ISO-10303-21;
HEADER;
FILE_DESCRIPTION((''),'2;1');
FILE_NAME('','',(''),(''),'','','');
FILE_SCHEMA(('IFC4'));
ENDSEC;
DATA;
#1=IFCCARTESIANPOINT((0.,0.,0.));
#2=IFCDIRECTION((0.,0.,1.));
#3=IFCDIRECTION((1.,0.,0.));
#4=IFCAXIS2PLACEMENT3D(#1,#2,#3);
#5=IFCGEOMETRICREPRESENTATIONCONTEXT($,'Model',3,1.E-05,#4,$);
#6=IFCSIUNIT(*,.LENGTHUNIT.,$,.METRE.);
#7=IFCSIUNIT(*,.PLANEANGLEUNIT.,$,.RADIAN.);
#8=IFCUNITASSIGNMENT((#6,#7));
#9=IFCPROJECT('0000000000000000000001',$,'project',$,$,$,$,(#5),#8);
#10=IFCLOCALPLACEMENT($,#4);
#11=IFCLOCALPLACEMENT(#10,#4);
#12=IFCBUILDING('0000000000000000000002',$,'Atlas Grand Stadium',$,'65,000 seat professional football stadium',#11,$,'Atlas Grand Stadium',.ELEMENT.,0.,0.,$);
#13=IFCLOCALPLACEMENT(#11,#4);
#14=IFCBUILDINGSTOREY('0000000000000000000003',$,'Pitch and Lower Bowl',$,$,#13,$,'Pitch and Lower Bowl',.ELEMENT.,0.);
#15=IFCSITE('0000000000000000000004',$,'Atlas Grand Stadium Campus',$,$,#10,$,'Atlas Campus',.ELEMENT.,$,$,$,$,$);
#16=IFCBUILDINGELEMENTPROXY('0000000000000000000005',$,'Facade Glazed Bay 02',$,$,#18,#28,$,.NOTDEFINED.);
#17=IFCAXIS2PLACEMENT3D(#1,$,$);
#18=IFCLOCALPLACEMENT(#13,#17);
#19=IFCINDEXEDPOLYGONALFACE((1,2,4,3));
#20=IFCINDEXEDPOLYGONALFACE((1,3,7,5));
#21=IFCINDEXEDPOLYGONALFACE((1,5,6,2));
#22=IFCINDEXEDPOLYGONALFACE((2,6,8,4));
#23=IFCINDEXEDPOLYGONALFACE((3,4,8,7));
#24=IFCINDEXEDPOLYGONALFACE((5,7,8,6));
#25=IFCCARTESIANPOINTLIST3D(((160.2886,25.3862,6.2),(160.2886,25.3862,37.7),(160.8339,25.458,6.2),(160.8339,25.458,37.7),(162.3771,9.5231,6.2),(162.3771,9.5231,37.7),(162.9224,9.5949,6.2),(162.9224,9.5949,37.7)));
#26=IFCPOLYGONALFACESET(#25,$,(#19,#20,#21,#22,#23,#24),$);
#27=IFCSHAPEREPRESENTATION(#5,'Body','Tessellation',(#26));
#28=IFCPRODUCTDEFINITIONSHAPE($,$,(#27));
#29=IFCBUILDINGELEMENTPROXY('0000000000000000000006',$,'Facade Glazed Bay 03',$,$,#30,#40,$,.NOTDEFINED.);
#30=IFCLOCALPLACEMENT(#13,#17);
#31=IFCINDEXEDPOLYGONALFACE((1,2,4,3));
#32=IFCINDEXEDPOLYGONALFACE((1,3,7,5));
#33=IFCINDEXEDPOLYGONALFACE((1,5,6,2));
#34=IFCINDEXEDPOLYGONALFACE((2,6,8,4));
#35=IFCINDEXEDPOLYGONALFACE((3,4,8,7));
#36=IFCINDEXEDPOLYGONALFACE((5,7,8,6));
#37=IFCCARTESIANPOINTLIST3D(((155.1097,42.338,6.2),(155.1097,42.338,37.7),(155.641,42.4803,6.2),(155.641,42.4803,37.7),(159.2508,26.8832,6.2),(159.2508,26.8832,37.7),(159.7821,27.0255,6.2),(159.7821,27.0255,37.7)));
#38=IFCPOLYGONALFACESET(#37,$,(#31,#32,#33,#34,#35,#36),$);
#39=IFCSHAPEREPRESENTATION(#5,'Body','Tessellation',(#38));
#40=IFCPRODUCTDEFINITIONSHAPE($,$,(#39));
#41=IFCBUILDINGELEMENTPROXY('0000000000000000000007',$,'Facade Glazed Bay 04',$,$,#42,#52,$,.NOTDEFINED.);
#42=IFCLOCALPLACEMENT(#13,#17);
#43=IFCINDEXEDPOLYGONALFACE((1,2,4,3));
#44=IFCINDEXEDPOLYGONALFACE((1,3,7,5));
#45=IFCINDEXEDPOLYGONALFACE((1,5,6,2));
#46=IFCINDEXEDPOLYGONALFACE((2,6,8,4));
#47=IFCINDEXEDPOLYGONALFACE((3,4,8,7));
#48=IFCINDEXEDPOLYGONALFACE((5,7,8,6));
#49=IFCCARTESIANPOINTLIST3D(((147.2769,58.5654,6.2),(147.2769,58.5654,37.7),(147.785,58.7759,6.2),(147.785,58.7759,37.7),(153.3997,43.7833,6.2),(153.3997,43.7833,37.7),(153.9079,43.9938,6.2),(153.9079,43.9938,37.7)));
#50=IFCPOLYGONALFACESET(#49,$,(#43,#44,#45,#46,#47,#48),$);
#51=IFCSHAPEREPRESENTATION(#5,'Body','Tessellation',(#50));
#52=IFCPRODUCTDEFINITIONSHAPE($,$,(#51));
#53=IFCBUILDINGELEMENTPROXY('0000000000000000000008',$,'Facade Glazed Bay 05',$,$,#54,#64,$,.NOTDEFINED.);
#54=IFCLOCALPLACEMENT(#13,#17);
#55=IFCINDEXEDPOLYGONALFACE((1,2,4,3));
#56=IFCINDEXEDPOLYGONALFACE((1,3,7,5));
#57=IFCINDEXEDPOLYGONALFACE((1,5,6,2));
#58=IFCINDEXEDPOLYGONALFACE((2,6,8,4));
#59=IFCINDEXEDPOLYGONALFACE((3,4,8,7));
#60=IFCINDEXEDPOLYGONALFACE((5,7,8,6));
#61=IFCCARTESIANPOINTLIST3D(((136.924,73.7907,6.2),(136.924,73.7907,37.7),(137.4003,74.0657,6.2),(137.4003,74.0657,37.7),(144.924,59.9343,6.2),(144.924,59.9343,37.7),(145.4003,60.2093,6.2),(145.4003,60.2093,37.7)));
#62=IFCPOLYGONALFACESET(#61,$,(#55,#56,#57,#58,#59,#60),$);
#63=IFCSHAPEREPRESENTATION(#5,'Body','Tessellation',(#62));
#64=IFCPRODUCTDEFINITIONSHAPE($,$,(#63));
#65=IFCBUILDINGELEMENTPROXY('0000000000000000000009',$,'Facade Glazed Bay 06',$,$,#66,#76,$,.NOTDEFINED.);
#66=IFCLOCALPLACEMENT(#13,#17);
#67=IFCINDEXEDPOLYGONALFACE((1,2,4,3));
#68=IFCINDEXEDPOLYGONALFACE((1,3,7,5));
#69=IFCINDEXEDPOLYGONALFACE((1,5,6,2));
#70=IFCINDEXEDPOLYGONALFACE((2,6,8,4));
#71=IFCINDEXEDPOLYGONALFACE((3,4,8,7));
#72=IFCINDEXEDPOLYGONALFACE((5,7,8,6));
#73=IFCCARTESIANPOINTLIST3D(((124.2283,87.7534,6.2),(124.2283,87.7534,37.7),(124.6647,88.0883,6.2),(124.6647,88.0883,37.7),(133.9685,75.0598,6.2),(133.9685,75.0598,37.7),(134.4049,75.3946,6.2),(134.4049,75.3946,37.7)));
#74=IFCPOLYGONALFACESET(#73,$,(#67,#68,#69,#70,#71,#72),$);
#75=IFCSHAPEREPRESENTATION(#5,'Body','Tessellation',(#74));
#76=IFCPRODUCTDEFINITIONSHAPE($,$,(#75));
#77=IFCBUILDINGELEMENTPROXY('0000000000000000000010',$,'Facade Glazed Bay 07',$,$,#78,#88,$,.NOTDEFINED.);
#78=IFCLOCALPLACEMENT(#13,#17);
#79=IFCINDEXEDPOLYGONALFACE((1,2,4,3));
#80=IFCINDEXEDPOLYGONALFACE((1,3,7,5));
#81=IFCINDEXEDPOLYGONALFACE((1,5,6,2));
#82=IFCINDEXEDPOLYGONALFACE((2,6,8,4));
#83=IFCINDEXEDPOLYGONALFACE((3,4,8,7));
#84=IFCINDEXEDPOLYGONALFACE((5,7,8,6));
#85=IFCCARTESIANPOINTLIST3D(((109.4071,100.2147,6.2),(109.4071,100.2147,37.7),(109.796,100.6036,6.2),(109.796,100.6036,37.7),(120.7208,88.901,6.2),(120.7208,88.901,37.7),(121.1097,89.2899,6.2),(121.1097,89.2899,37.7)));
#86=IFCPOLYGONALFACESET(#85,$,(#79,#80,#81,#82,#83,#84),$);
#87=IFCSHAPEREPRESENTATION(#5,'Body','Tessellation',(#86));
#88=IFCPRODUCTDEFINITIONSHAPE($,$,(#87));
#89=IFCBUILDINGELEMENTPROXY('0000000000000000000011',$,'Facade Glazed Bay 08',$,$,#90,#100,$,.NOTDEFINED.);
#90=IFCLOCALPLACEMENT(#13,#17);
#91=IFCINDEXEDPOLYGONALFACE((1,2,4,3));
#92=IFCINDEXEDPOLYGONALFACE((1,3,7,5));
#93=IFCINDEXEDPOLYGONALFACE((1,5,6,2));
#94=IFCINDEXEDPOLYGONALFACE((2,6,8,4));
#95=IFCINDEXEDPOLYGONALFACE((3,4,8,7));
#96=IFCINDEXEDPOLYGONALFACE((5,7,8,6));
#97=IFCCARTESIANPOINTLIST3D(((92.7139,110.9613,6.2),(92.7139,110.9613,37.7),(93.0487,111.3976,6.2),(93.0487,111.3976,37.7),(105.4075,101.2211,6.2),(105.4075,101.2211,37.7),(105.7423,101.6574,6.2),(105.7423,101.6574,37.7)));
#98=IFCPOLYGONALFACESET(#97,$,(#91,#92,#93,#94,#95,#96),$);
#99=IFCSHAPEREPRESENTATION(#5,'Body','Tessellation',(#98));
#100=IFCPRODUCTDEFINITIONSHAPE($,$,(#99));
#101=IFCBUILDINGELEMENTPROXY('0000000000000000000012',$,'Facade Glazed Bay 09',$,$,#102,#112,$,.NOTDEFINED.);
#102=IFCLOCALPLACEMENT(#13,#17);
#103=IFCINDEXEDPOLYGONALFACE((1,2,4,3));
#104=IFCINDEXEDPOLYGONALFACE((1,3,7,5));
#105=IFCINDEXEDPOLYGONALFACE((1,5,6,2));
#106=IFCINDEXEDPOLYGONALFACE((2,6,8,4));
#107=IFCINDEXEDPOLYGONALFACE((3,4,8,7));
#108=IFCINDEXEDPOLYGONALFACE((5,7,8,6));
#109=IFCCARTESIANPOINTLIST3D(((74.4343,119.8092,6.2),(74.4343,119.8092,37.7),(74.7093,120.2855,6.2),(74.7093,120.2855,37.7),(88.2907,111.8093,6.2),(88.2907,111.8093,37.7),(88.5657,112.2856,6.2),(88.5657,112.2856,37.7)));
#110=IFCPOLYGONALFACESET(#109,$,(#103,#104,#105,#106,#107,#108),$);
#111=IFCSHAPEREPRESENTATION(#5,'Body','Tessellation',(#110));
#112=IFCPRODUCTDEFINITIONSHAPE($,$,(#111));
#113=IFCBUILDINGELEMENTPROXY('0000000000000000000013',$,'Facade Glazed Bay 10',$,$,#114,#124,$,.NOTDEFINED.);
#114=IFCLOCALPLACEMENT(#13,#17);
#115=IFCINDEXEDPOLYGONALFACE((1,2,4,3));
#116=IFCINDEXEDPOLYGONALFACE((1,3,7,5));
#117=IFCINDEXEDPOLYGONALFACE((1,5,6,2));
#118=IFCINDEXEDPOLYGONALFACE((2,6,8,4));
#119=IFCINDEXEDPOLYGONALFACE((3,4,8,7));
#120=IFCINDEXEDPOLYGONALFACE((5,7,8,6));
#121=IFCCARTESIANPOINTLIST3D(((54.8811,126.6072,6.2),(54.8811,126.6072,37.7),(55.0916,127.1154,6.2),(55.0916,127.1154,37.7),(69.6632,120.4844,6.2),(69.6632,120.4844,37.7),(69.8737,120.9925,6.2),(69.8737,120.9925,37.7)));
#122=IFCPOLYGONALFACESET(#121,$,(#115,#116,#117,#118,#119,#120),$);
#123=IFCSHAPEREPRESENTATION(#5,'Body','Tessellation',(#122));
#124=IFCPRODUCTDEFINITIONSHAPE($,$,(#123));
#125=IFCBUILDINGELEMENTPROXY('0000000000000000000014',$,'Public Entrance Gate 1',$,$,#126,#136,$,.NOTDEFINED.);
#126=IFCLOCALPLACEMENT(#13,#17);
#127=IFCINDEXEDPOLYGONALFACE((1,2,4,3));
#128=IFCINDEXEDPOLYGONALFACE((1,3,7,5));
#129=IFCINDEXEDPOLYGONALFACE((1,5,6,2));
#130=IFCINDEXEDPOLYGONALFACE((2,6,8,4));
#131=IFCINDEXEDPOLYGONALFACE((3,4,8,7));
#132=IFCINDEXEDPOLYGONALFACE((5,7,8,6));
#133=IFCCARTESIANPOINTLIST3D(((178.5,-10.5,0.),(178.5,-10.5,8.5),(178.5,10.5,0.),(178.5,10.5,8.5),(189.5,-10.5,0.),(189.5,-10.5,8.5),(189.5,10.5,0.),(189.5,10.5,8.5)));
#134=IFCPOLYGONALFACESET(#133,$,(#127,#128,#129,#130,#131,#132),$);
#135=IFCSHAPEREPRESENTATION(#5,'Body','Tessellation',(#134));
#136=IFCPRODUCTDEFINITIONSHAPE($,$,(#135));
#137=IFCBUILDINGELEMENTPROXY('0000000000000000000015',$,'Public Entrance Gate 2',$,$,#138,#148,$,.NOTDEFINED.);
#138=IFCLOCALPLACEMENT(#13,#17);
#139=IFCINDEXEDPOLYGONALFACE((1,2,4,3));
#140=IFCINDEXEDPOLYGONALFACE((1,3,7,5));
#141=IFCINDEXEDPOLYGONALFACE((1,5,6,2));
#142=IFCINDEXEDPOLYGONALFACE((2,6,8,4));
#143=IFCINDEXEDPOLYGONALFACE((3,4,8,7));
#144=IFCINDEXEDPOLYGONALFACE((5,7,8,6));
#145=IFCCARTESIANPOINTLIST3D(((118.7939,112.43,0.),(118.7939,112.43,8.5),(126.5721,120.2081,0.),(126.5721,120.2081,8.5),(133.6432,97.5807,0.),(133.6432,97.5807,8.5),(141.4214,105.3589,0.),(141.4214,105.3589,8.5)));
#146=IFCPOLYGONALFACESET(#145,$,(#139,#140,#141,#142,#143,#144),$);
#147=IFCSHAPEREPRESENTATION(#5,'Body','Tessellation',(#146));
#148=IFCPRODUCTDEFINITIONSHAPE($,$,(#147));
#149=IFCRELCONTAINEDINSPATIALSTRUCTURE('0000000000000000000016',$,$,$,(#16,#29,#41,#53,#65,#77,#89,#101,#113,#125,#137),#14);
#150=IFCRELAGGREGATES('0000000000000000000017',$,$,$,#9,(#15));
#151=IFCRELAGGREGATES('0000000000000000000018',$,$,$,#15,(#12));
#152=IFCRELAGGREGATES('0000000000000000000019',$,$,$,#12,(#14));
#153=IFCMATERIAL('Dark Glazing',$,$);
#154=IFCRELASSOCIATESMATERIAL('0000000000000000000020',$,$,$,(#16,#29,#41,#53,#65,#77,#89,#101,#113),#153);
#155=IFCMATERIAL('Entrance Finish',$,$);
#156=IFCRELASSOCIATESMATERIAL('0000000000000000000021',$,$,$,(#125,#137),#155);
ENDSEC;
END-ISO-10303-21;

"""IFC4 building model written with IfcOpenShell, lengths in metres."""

from ifc_helpers import new_model, si_unit, frame, origin_with_axes, origin_2d_with_axis, place, context, project, spatial, rectangle, extrude, material, element, save


model = new_model("IFC4")

# Units and contexts
model_context = context("Model", 3, precision=1e-05, world=origin_with_axes())
ifc_project = project(units=[si_unit("LENGTHUNIT", "METRE"), si_unit("PLANEANGLEUNIT", "RADIAN")], contexts=[model_context])

# Site, building, storey
site_placement = place(None, origin_with_axes())
site = spatial("IfcSite", under=ifc_project, at=site_placement, Name="Atlas Grand Stadium Campus", LongName="Atlas Campus", CompositionType="ELEMENT")
building_placement = place(site_placement, origin_with_axes())
building = spatial("IfcBuilding", under=site, at=building_placement, Name="Atlas Grand Stadium", ObjectType="65,000 seat professional football stadium", LongName="Atlas Grand Stadium", CompositionType="ELEMENT", ElevationOfRefHeight=0.0, ElevationOfTerrain=0.0)
storey_placement = place(building_placement, origin_with_axes())
storey = spatial("IfcBuildingStorey", under=building, at=storey_placement, Name="Pitch and Lower Bowl", LongName="Pitch and Lower Bowl", CompositionType="ELEMENT", Elevation=0.0)

# Building element proxies
ifc_material_1 = material(Name="Dark Glazing")
for number, where, z_axis, x_axis, name in (
    (1, (161.6055, 17.4905, 6.2), (0.0, 0.0, 1.0), (-0.13053, 0.99144, 0.0), "Facade Glazed Bay 02"),
    (2, (157.4459, 34.6818, 6.2), (0.0, 0.0, 1.0), (-0.25882, 0.96593, 0.0), "Facade Glazed Bay 03"),
    (3, (150.5924, 51.2796, 6.2), (0.0, 0.0, 1.0), (-0.38268, 0.92388, 0.0), "Facade Glazed Bay 04"),
    (4, (141.1621, 67.0, 6.2), (0.0, 0.0, 1.0), (-0.5, 0.86603, 0.0), "Facade Glazed Bay 05"),
    (5, (129.3166, 81.574, 6.2), (0.0, 0.0, 1.0), (-0.60876, 0.79335, 0.0), "Facade Glazed Bay 06"),
    (6, (115.2584, 94.7523, 6.2), (0.0, 0.0, 1.0), (-0.70711, 0.70711, 0.0), "Facade Glazed Bay 07"),
    (7, (99.2281, 106.3093, 6.2), (0.0, 0.0, 1.0), (-0.79335, 0.60876, 0.0), "Facade Glazed Bay 08"),
    (8, (81.5, 116.0474, 6.2), (0.0, 0.0, 1.0), (-0.86603, 0.5, 0.0), "Facade Glazed Bay 09"),
    (9, (62.3774, 123.7999, 6.2), (0.0, 0.0, 1.0), (-0.92388, 0.38268, 0.0), "Facade Glazed Bay 10"),
):
    element("IfcBuildingElementProxy", number, at=place(storey_placement, frame(where, z_axis=z_axis, x_axis=x_axis)), inside=storey, material=ifc_material_1, Name=name, PredefinedType="NOTDEFINED", context=model_context, shape_type="SweptSolid", body=[
        extrude(rectangle(XDim=16.0, YDim=0.55, at=origin_2d_with_axis()), origin_with_axes(), (0.0, 0.0, 1.0), 31.5),
    ])
ifc_material_2 = material(Name="Entrance Finish")
for number, where, z_axis, x_axis, name in (
    (10, (184.0, 0.0, 0.0), (0.0, 0.0, 1.0), (0.0, 1.0, 0.0), "Public Entrance Gate 1"),
    (11, (130.1077, 108.8944, 0.0), (0.0, 0.0, 1.0), (-0.70711, 0.70711, 0.0), "Public Entrance Gate 2"),
):
    element("IfcBuildingElementProxy", number, at=place(storey_placement, frame(where, z_axis=z_axis, x_axis=x_axis)), inside=storey, material=ifc_material_2, Name=name, PredefinedType="NOTDEFINED", context=model_context, shape_type="SweptSolid", body=[
        extrude(rectangle(XDim=21.0, YDim=11.0, at=origin_2d_with_axis()), origin_with_axes(), (0.0, 0.0, 1.0), 8.5),
    ])

save(model, "model.ifc")
